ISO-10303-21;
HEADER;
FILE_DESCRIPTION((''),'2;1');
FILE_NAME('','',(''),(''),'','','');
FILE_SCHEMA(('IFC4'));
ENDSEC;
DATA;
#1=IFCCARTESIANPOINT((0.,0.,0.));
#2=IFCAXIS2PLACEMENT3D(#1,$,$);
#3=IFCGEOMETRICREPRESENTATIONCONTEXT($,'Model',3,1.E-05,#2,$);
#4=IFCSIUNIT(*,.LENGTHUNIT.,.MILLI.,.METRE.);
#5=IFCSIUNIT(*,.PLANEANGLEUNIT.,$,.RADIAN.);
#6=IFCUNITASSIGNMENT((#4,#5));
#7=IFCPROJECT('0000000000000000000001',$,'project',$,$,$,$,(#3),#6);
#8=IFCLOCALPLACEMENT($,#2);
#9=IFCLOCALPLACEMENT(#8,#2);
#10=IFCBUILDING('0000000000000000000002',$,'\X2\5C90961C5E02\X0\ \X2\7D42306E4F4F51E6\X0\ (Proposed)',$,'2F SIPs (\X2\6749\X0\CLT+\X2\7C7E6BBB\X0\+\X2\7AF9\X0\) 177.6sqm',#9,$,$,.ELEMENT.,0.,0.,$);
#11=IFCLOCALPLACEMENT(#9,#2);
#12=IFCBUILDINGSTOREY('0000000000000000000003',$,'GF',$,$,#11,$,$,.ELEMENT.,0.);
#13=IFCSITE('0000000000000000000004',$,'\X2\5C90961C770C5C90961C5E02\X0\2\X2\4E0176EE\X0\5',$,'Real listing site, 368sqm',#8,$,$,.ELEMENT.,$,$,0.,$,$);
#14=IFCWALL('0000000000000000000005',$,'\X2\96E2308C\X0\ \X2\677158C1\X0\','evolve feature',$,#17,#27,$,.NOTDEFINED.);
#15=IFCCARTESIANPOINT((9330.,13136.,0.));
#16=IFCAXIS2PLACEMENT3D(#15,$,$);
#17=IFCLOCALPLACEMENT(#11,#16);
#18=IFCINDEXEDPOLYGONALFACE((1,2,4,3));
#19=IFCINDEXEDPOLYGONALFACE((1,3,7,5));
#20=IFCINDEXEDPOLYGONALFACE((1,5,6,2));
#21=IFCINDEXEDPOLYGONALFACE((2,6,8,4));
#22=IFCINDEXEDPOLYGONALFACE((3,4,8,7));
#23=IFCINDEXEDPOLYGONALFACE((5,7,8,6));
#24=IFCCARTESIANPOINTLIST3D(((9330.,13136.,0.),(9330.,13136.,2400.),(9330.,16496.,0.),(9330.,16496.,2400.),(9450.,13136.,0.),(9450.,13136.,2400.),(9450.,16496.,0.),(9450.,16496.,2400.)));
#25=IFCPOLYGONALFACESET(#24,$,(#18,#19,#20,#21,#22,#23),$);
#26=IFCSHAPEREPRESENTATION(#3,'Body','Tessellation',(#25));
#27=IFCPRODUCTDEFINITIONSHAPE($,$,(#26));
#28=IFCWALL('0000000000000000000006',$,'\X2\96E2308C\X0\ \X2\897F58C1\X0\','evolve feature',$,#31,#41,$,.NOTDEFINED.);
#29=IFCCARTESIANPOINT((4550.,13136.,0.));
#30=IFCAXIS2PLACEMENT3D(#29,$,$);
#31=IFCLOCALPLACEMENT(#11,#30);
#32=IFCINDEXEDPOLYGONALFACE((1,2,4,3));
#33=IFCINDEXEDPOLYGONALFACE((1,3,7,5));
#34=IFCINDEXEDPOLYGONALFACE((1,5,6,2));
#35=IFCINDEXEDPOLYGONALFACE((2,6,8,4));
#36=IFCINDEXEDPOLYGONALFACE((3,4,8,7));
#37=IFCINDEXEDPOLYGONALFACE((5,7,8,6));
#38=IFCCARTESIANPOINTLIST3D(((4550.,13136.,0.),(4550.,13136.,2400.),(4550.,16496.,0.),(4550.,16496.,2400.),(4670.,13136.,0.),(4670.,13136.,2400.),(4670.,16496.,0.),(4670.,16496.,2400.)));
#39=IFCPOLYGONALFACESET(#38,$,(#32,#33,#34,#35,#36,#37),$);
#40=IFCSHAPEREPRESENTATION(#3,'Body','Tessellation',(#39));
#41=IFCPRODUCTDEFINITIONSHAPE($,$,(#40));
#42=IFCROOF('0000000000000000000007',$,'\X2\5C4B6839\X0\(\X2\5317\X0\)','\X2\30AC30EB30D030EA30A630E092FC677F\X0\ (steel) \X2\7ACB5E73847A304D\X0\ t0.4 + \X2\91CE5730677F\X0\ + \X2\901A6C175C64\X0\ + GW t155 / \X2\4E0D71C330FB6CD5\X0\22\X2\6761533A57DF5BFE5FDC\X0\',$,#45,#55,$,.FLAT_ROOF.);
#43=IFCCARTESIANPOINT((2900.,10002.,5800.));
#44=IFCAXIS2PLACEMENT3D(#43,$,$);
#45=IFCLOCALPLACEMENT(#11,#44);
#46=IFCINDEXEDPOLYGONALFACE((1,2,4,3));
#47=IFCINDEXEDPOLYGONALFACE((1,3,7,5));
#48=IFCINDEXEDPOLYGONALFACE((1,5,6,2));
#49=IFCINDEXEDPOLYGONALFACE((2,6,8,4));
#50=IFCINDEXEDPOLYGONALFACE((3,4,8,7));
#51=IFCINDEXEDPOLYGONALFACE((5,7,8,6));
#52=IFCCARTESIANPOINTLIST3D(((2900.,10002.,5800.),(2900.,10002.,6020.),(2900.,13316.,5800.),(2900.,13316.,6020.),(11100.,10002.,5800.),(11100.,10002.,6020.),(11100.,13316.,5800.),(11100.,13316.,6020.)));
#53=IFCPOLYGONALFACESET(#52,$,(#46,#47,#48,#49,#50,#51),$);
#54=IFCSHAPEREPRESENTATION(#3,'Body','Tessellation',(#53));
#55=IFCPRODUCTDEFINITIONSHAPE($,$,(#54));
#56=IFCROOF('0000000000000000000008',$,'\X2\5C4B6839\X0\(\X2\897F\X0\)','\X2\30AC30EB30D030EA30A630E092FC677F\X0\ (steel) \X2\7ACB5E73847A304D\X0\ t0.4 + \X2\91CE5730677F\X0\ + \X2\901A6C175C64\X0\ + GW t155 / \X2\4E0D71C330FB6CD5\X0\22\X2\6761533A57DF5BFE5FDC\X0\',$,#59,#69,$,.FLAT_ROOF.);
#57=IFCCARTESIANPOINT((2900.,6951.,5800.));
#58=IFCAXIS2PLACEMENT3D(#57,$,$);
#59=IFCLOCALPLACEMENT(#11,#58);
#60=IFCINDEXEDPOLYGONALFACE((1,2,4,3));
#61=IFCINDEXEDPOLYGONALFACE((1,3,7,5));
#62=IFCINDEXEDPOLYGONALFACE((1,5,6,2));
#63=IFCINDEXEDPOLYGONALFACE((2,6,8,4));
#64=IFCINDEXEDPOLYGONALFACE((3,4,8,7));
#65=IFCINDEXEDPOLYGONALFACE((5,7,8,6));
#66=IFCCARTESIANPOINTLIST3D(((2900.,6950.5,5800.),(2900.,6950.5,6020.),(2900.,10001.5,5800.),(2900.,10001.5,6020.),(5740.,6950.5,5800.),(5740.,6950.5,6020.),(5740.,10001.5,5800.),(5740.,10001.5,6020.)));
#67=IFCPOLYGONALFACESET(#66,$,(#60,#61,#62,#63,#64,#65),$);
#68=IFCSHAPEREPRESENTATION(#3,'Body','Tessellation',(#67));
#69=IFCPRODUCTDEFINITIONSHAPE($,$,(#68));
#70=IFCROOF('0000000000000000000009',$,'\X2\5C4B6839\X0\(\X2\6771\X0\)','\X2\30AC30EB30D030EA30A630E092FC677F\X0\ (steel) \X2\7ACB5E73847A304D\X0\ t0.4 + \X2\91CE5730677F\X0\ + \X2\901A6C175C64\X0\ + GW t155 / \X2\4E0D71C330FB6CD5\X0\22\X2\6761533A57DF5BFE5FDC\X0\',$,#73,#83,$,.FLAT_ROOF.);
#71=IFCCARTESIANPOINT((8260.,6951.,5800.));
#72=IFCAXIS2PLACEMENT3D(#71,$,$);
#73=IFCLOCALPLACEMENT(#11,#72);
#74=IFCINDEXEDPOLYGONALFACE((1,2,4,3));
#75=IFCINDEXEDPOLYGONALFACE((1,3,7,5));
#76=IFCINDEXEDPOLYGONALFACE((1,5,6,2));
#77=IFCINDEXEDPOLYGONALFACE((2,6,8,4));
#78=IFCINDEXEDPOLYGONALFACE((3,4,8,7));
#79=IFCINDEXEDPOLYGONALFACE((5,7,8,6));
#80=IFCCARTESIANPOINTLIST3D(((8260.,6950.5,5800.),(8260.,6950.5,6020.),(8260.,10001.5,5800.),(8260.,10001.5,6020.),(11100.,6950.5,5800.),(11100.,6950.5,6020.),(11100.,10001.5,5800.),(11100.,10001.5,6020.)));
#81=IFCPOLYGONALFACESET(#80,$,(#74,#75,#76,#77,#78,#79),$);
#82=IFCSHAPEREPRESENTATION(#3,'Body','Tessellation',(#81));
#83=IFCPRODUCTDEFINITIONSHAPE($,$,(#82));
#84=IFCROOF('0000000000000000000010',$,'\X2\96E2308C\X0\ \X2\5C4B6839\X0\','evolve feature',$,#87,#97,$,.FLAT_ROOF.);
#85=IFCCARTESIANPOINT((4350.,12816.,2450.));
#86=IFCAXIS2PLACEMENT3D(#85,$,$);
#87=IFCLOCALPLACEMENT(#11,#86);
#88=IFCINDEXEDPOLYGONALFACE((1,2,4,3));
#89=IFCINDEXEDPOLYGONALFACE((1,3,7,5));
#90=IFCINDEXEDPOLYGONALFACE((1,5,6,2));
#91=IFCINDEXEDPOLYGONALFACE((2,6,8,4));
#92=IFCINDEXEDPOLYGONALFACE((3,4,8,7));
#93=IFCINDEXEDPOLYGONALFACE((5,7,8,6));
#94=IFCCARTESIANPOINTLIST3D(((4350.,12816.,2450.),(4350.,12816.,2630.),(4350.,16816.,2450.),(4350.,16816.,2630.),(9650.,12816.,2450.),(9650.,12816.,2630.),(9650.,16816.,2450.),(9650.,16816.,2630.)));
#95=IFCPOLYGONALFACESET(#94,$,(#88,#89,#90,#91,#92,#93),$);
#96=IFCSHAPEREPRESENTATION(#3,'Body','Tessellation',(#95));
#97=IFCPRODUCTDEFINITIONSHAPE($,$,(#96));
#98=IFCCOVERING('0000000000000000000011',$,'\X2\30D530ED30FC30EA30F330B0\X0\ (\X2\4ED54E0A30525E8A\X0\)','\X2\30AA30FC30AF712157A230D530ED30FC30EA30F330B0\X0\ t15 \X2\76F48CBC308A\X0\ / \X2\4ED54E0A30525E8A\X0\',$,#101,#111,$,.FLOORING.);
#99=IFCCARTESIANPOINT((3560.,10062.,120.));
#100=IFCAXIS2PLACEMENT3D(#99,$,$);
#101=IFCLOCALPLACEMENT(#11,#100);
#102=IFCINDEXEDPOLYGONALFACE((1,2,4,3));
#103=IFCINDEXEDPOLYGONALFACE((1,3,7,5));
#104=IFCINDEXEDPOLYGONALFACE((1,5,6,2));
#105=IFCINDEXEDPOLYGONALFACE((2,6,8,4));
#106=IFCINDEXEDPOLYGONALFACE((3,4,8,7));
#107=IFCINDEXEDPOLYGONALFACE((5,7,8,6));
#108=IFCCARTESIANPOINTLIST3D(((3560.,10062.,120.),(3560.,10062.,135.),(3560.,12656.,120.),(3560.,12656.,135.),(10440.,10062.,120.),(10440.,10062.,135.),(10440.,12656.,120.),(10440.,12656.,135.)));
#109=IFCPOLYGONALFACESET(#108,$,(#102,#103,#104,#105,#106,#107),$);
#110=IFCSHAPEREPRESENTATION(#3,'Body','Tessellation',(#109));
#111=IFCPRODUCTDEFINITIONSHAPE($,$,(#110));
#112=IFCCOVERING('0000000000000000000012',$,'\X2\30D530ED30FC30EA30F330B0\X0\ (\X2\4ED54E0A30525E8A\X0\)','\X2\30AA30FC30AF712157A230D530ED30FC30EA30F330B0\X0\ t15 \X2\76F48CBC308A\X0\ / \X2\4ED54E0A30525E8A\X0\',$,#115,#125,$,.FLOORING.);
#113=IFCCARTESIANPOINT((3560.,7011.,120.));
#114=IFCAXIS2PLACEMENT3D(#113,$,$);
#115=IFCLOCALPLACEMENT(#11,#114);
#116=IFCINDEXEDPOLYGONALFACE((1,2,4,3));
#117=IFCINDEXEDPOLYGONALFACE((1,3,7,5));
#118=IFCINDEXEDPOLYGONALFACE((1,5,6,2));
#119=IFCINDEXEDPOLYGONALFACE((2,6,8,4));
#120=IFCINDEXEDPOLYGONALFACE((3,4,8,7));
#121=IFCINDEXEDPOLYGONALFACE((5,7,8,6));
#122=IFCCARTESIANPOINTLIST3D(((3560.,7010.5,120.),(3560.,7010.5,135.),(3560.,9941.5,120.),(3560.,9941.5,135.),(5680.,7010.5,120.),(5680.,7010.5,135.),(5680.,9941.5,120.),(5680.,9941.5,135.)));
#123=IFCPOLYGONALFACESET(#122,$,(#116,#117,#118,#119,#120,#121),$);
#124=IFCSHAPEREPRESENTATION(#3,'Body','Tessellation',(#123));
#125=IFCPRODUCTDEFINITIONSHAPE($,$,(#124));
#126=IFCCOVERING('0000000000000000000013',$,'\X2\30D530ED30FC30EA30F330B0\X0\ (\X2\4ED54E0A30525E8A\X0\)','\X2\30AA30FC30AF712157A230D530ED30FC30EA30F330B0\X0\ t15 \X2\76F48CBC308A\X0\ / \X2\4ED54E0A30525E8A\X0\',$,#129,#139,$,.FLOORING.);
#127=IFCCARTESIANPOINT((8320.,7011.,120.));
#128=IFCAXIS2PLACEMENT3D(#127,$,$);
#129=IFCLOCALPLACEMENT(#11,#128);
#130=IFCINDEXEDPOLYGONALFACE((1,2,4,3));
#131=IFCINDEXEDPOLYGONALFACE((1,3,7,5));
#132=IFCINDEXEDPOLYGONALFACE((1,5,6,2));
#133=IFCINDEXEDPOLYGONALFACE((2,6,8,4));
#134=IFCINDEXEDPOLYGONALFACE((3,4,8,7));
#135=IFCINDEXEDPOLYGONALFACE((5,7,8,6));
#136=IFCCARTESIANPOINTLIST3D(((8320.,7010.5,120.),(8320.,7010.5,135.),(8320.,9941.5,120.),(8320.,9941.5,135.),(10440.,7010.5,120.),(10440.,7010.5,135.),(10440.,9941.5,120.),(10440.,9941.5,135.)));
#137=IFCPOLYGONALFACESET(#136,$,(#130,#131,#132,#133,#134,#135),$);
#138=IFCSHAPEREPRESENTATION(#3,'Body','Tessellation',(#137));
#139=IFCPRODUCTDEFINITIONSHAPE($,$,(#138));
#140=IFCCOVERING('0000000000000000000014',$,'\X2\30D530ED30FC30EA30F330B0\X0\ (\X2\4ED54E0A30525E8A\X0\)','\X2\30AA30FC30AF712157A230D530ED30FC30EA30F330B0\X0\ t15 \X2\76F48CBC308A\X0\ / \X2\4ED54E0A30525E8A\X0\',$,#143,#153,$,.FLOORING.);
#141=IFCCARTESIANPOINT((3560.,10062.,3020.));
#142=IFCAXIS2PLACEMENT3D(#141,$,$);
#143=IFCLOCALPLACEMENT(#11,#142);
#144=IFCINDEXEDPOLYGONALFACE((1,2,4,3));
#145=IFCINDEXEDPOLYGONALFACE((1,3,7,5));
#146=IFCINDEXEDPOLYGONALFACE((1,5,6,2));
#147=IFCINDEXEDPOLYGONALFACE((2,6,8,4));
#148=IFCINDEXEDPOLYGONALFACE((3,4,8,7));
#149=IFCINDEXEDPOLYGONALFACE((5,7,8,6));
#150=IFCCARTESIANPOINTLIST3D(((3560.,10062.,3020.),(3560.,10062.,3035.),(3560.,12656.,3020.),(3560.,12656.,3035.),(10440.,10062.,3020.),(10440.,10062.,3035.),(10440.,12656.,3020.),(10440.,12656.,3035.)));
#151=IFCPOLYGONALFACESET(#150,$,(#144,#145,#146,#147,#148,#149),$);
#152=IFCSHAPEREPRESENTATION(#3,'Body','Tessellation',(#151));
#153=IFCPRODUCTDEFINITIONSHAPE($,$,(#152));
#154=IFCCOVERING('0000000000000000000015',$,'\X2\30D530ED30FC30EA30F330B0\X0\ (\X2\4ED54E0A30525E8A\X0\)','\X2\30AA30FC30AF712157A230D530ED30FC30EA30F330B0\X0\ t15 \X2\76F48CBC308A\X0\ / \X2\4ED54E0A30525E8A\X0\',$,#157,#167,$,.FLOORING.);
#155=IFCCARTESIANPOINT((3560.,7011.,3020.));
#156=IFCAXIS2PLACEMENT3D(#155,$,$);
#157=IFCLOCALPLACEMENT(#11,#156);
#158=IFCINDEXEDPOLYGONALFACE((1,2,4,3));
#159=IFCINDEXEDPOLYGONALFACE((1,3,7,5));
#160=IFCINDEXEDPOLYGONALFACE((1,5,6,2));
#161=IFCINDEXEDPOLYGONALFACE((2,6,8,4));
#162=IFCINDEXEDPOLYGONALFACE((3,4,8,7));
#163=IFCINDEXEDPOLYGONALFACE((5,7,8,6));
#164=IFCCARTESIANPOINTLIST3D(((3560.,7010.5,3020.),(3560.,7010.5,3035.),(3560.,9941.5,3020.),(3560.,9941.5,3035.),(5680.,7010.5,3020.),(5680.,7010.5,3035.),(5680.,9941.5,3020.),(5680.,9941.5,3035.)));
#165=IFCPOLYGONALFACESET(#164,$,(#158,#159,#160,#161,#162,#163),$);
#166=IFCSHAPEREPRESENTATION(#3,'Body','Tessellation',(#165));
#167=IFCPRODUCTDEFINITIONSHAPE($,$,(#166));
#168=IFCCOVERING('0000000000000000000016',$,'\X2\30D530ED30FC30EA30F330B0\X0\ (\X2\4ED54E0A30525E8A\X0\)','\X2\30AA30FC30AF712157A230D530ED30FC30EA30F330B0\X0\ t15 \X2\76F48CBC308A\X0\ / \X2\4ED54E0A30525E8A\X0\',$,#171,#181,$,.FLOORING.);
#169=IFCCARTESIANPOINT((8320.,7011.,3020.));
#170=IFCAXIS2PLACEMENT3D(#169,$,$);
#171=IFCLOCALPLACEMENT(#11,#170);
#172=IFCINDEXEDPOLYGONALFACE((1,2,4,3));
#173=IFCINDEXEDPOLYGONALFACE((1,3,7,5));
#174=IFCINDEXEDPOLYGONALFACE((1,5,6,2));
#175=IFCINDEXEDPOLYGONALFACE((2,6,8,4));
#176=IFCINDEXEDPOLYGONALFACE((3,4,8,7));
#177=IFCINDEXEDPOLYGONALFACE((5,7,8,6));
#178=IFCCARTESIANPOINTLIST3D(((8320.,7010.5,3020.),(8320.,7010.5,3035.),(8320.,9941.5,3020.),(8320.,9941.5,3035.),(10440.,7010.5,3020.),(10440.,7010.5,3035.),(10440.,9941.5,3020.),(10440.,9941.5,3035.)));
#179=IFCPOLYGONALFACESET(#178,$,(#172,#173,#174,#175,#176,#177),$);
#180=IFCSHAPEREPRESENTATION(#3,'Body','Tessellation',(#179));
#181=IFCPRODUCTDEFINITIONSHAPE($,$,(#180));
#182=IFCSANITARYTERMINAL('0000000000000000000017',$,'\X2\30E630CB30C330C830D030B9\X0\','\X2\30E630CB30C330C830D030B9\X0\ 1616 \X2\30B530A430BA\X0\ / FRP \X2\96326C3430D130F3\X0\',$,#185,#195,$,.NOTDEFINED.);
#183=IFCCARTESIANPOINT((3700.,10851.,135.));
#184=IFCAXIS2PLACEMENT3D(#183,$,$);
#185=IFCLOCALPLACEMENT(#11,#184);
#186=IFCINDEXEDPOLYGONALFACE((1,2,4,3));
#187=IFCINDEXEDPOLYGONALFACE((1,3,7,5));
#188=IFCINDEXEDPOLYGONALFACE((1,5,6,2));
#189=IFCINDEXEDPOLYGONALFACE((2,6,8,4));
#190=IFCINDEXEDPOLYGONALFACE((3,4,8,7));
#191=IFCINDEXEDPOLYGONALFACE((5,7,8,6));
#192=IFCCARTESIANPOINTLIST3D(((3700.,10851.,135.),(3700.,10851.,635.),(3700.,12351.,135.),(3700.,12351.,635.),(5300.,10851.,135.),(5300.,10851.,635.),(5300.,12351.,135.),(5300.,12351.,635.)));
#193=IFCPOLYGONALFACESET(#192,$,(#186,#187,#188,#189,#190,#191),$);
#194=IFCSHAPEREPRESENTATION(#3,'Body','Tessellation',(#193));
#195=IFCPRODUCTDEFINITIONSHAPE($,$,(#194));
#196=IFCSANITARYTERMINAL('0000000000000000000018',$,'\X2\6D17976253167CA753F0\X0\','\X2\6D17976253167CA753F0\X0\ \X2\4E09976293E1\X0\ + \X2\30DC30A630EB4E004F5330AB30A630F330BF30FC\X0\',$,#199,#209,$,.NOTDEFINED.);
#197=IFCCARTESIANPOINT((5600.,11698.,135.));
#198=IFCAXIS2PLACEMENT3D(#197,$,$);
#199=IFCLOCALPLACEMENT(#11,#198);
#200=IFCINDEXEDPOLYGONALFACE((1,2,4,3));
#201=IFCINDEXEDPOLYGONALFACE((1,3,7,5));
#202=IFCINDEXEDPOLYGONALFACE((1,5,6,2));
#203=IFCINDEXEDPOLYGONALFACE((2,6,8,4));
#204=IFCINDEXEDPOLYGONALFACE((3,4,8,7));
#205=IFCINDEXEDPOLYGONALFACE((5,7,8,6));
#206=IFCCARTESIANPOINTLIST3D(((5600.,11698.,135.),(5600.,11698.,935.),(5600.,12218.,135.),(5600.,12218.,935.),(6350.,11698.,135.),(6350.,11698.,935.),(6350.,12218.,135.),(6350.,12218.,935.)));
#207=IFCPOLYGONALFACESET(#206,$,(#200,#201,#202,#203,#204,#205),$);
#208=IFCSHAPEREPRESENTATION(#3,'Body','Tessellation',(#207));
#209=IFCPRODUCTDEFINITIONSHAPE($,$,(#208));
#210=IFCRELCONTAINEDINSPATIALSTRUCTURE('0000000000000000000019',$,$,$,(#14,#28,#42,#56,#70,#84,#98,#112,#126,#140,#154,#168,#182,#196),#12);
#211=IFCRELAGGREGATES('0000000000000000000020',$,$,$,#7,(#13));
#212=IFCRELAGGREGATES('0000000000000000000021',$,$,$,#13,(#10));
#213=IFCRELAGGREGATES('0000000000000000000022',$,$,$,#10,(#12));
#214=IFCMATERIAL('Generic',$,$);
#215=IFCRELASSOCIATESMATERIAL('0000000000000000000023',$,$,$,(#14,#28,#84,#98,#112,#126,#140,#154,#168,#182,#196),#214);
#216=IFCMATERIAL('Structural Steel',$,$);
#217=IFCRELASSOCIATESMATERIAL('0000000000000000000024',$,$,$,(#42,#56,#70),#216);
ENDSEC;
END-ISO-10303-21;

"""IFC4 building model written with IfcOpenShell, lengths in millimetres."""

from ifc_helpers import new_model, si_unit, frame, frame_2d, origin, place, context, project, spatial, rectangle, extrude, material, element, save


model = new_model("IFC4")

# Units and contexts
model_context = context("Model", 3, precision=1e-05, world=origin())
ifc_project = project(units=[si_unit("LENGTHUNIT", "METRE", prefix="MILLI"), si_unit("PLANEANGLEUNIT", "RADIAN")], contexts=[model_context])

# Site, building, storey
site_placement = place(None, origin())
site = spatial("IfcSite", under=ifc_project, at=site_placement, Name="岐阜県岐阜市2丁目5", ObjectType="Real listing site, 368sqm", CompositionType="ELEMENT", RefElevation=0.0)
building_placement = place(site_placement, origin())
building = spatial("IfcBuilding", under=site, at=building_placement, Name="岐阜市 終の住処 (Proposed)", ObjectType="2F SIPs (杉CLT+籾殻+竹) 177.6sqm", CompositionType="ELEMENT", ElevationOfRefHeight=0.0, ElevationOfTerrain=0.0)
storey_placement = place(building_placement, origin())
storey = spatial("IfcBuildingStorey", under=building, at=storey_placement, Name="GF", CompositionType="ELEMENT", Elevation=0.0)

# Shared definitions
ifc_material_1 = material(Name="Generic")

# Walls
wall_1_placement = place(storey_placement, frame((9330.0, 13136.0, 0.0)))
element("IfcWall", 1, at=wall_1_placement, inside=storey, material=ifc_material_1, Name="離れ 東壁", Description="evolve feature", PredefinedType="NOTDEFINED", context=model_context, shape_type="SweptSolid", body=[
    extrude(rectangle(XDim=120.0, YDim=3360.0, at=frame_2d((60.0, 1680.0))), frame((9330.0, 13136.0, 0.0)), (0.0, 0.0, 1.0), 2400.0),
])
wall_2_placement = place(storey_placement, frame((4550.0, 13136.0, 0.0)))
element("IfcWall", 2, at=wall_2_placement, inside=storey, material=ifc_material_1, Name="離れ 西壁", Description="evolve feature", PredefinedType="NOTDEFINED", context=model_context, shape_type="SweptSolid", body=[
    extrude(rectangle(XDim=120.0, YDim=3360.0, at=frame_2d((60.0, 1680.0))), frame((4550.0, 13136.0, 0.0)), (0.0, 0.0, 1.0), 2400.0),
])

# Roofs
ifc_material_2 = material(Name="Structural Steel")
for number, where, name in (
    (3, (2900.0, 10002.0, 5800.0), "屋根(北)"),
):
    element("IfcRoof", number, at=place(storey_placement, frame(where)), inside=storey, material=ifc_material_2, Name=name, Description="ガルバリウム鋼板 (steel) 立平葺き t0.4 + 野地板 + 通気層 + GW t155 / 不燃・法22条区域対応", PredefinedType="FLAT_ROOF", context=model_context, shape_type="SweptSolid", body=[
        extrude(rectangle(XDim=8200.0, YDim=3314.0, at=frame_2d((4100.0, 1657.0))), frame((2900.0, 10002.0, 5800.0)), (0.0, 0.0, 1.0), 220.0),
    ])
roof_1_placement = place(storey_placement, frame((2900.0, 6951.0, 5800.0)))
element("IfcRoof", 4, at=roof_1_placement, inside=storey, material=ifc_material_2, Name="屋根(西)", Description="ガルバリウム鋼板 (steel) 立平葺き t0.4 + 野地板 + 通気層 + GW t155 / 不燃・法22条区域対応", PredefinedType="FLAT_ROOF", context=model_context, shape_type="SweptSolid", body=[
    extrude(rectangle(XDim=2840.0, YDim=3051.0, at=frame_2d((1420.0, 1525.0))), frame((2900.0, 6951.0, 5800.0)), (0.0, 0.0, 1.0), 220.0),
])
roof_2_placement = place(storey_placement, frame((8260.0, 6951.0, 5800.0)))
element("IfcRoof", 5, at=roof_2_placement, inside=storey, material=ifc_material_2, Name="屋根(東)", Description="ガルバリウム鋼板 (steel) 立平葺き t0.4 + 野地板 + 通気層 + GW t155 / 不燃・法22条区域対応", PredefinedType="FLAT_ROOF", context=model_context, shape_type="SweptSolid", body=[
    extrude(rectangle(XDim=2840.0, YDim=3051.0, at=frame_2d((1420.0, 1525.0))), frame((8260.0, 6951.0, 5800.0)), (0.0, 0.0, 1.0), 220.0),
])
roof_3_placement = place(storey_placement, frame((4350.0, 12816.0, 2450.0)))
element("IfcRoof", 6, at=roof_3_placement, inside=storey, material=ifc_material_1, Name="離れ 屋根", Description="evolve feature", PredefinedType="FLAT_ROOF", context=model_context, shape_type="SweptSolid", body=[
    extrude(rectangle(XDim=5300.0, YDim=4000.0, at=frame_2d((2650.0, 2000.0))), frame((4350.0, 12816.0, 2450.0)), (0.0, 0.0, 1.0), 180.0),
])

# Coverings
covering_1_placement = place(storey_placement, frame((3560.0, 10062.0, 120.0)))
element("IfcCovering", 7, at=covering_1_placement, inside=storey, material=ifc_material_1, Name="フローリング (仕上げ床)", Description="オーク無垢フローリング t15 直貼り / 仕上げ床", PredefinedType="FLOORING", context=model_context, shape_type="SweptSolid", body=[
    extrude(rectangle(XDim=6880.0, YDim=2594.0, at=frame_2d((3440.0, 1297.0))), frame((3560.0, 10062.0, 120.0)), (0.0, 0.0, 1.0), 15.0),
])
covering_2_placement = place(storey_placement, frame((3560.0, 7011.0, 120.0)))
element("IfcCovering", 8, at=covering_2_placement, inside=storey, material=ifc_material_1, Name="フローリング (仕上げ床)", Description="オーク無垢フローリング t15 直貼り / 仕上げ床", PredefinedType="FLOORING", context=model_context, shape_type="SweptSolid", body=[
    extrude(rectangle(XDim=2120.0, YDim=2931.0, at=frame_2d((1060.0, 1465.0))), frame((3560.0, 7011.0, 120.0)), (0.0, 0.0, 1.0), 15.0),
])
covering_3_placement = place(storey_placement, frame((8320.0, 7011.0, 120.0)))
element("IfcCovering", 9, at=covering_3_placement, inside=storey, material=ifc_material_1, Name="フローリング (仕上げ床)", Description="オーク無垢フローリング t15 直貼り / 仕上げ床", PredefinedType="FLOORING", context=model_context, shape_type="SweptSolid", body=[
    extrude(rectangle(XDim=2120.0, YDim=2931.0, at=frame_2d((1060.0, 1465.0))), frame((8320.0, 7011.0, 120.0)), (0.0, 0.0, 1.0), 15.0),
])
covering_4_placement = place(storey_placement, frame((3560.0, 10062.0, 3020.0)))
element("IfcCovering", 10, at=covering_4_placement, inside=storey, material=ifc_material_1, Name="フローリング (仕上げ床)", Description="オーク無垢フローリング t15 直貼り / 仕上げ床", PredefinedType="FLOORING", context=model_context, shape_type="SweptSolid", body=[
    extrude(rectangle(XDim=6880.0, YDim=2594.0, at=frame_2d((3440.0, 1297.0))), frame((3560.0, 10062.0, 3020.0)), (0.0, 0.0, 1.0), 15.0),
])
covering_5_placement = place(storey_placement, frame((3560.0, 7011.0, 3020.0)))
element("IfcCovering", 11, at=covering_5_placement, inside=storey, material=ifc_material_1, Name="フローリング (仕上げ床)", Description="オーク無垢フローリング t15 直貼り / 仕上げ床", PredefinedType="FLOORING", context=model_context, shape_type="SweptSolid", body=[
    extrude(rectangle(XDim=2120.0, YDim=2931.0, at=frame_2d((1060.0, 1465.0))), frame((3560.0, 7011.0, 3020.0)), (0.0, 0.0, 1.0), 15.0),
])
covering_6_placement = place(storey_placement, frame((8320.0, 7011.0, 3020.0)))
element("IfcCovering", 12, at=covering_6_placement, inside=storey, material=ifc_material_1, Name="フローリング (仕上げ床)", Description="オーク無垢フローリング t15 直貼り / 仕上げ床", PredefinedType="FLOORING", context=model_context, shape_type="SweptSolid", body=[
    extrude(rectangle(XDim=2120.0, YDim=2931.0, at=frame_2d((1060.0, 1465.0))), frame((8320.0, 7011.0, 3020.0)), (0.0, 0.0, 1.0), 15.0),
])

# Sanitary terminals
sanitary_terminal_1_placement = place(storey_placement, frame((3700.0, 10851.0, 135.0)))
element("IfcSanitaryTerminal", 13, at=sanitary_terminal_1_placement, inside=storey, material=ifc_material_1, Name="ユニットバス", Description="ユニットバス 1616 サイズ / FRP 防水パン", PredefinedType="NOTDEFINED", context=model_context, shape_type="SweptSolid", body=[
    extrude(rectangle(XDim=1600.0, YDim=1500.0, at=frame_2d((800.0, 750.0))), frame((3700.0, 10851.0, 135.0)), (0.0, 0.0, 1.0), 500.0),
])
sanitary_terminal_2_placement = place(storey_placement, frame((5600.0, 11698.0, 135.0)))
element("IfcSanitaryTerminal", 14, at=sanitary_terminal_2_placement, inside=storey, material=ifc_material_1, Name="洗面化粧台", Description="洗面化粧台 三面鏡 + ボウル一体カウンター", PredefinedType="NOTDEFINED", context=model_context, shape_type="SweptSolid", body=[
    extrude(rectangle(XDim=750.0, YDim=520.0, at=frame_2d((375.0, 260.0))), frame((5600.0, 11698.0, 135.0)), (0.0, 0.0, 1.0), 800.0),
])

save(model, "model.ifc")
